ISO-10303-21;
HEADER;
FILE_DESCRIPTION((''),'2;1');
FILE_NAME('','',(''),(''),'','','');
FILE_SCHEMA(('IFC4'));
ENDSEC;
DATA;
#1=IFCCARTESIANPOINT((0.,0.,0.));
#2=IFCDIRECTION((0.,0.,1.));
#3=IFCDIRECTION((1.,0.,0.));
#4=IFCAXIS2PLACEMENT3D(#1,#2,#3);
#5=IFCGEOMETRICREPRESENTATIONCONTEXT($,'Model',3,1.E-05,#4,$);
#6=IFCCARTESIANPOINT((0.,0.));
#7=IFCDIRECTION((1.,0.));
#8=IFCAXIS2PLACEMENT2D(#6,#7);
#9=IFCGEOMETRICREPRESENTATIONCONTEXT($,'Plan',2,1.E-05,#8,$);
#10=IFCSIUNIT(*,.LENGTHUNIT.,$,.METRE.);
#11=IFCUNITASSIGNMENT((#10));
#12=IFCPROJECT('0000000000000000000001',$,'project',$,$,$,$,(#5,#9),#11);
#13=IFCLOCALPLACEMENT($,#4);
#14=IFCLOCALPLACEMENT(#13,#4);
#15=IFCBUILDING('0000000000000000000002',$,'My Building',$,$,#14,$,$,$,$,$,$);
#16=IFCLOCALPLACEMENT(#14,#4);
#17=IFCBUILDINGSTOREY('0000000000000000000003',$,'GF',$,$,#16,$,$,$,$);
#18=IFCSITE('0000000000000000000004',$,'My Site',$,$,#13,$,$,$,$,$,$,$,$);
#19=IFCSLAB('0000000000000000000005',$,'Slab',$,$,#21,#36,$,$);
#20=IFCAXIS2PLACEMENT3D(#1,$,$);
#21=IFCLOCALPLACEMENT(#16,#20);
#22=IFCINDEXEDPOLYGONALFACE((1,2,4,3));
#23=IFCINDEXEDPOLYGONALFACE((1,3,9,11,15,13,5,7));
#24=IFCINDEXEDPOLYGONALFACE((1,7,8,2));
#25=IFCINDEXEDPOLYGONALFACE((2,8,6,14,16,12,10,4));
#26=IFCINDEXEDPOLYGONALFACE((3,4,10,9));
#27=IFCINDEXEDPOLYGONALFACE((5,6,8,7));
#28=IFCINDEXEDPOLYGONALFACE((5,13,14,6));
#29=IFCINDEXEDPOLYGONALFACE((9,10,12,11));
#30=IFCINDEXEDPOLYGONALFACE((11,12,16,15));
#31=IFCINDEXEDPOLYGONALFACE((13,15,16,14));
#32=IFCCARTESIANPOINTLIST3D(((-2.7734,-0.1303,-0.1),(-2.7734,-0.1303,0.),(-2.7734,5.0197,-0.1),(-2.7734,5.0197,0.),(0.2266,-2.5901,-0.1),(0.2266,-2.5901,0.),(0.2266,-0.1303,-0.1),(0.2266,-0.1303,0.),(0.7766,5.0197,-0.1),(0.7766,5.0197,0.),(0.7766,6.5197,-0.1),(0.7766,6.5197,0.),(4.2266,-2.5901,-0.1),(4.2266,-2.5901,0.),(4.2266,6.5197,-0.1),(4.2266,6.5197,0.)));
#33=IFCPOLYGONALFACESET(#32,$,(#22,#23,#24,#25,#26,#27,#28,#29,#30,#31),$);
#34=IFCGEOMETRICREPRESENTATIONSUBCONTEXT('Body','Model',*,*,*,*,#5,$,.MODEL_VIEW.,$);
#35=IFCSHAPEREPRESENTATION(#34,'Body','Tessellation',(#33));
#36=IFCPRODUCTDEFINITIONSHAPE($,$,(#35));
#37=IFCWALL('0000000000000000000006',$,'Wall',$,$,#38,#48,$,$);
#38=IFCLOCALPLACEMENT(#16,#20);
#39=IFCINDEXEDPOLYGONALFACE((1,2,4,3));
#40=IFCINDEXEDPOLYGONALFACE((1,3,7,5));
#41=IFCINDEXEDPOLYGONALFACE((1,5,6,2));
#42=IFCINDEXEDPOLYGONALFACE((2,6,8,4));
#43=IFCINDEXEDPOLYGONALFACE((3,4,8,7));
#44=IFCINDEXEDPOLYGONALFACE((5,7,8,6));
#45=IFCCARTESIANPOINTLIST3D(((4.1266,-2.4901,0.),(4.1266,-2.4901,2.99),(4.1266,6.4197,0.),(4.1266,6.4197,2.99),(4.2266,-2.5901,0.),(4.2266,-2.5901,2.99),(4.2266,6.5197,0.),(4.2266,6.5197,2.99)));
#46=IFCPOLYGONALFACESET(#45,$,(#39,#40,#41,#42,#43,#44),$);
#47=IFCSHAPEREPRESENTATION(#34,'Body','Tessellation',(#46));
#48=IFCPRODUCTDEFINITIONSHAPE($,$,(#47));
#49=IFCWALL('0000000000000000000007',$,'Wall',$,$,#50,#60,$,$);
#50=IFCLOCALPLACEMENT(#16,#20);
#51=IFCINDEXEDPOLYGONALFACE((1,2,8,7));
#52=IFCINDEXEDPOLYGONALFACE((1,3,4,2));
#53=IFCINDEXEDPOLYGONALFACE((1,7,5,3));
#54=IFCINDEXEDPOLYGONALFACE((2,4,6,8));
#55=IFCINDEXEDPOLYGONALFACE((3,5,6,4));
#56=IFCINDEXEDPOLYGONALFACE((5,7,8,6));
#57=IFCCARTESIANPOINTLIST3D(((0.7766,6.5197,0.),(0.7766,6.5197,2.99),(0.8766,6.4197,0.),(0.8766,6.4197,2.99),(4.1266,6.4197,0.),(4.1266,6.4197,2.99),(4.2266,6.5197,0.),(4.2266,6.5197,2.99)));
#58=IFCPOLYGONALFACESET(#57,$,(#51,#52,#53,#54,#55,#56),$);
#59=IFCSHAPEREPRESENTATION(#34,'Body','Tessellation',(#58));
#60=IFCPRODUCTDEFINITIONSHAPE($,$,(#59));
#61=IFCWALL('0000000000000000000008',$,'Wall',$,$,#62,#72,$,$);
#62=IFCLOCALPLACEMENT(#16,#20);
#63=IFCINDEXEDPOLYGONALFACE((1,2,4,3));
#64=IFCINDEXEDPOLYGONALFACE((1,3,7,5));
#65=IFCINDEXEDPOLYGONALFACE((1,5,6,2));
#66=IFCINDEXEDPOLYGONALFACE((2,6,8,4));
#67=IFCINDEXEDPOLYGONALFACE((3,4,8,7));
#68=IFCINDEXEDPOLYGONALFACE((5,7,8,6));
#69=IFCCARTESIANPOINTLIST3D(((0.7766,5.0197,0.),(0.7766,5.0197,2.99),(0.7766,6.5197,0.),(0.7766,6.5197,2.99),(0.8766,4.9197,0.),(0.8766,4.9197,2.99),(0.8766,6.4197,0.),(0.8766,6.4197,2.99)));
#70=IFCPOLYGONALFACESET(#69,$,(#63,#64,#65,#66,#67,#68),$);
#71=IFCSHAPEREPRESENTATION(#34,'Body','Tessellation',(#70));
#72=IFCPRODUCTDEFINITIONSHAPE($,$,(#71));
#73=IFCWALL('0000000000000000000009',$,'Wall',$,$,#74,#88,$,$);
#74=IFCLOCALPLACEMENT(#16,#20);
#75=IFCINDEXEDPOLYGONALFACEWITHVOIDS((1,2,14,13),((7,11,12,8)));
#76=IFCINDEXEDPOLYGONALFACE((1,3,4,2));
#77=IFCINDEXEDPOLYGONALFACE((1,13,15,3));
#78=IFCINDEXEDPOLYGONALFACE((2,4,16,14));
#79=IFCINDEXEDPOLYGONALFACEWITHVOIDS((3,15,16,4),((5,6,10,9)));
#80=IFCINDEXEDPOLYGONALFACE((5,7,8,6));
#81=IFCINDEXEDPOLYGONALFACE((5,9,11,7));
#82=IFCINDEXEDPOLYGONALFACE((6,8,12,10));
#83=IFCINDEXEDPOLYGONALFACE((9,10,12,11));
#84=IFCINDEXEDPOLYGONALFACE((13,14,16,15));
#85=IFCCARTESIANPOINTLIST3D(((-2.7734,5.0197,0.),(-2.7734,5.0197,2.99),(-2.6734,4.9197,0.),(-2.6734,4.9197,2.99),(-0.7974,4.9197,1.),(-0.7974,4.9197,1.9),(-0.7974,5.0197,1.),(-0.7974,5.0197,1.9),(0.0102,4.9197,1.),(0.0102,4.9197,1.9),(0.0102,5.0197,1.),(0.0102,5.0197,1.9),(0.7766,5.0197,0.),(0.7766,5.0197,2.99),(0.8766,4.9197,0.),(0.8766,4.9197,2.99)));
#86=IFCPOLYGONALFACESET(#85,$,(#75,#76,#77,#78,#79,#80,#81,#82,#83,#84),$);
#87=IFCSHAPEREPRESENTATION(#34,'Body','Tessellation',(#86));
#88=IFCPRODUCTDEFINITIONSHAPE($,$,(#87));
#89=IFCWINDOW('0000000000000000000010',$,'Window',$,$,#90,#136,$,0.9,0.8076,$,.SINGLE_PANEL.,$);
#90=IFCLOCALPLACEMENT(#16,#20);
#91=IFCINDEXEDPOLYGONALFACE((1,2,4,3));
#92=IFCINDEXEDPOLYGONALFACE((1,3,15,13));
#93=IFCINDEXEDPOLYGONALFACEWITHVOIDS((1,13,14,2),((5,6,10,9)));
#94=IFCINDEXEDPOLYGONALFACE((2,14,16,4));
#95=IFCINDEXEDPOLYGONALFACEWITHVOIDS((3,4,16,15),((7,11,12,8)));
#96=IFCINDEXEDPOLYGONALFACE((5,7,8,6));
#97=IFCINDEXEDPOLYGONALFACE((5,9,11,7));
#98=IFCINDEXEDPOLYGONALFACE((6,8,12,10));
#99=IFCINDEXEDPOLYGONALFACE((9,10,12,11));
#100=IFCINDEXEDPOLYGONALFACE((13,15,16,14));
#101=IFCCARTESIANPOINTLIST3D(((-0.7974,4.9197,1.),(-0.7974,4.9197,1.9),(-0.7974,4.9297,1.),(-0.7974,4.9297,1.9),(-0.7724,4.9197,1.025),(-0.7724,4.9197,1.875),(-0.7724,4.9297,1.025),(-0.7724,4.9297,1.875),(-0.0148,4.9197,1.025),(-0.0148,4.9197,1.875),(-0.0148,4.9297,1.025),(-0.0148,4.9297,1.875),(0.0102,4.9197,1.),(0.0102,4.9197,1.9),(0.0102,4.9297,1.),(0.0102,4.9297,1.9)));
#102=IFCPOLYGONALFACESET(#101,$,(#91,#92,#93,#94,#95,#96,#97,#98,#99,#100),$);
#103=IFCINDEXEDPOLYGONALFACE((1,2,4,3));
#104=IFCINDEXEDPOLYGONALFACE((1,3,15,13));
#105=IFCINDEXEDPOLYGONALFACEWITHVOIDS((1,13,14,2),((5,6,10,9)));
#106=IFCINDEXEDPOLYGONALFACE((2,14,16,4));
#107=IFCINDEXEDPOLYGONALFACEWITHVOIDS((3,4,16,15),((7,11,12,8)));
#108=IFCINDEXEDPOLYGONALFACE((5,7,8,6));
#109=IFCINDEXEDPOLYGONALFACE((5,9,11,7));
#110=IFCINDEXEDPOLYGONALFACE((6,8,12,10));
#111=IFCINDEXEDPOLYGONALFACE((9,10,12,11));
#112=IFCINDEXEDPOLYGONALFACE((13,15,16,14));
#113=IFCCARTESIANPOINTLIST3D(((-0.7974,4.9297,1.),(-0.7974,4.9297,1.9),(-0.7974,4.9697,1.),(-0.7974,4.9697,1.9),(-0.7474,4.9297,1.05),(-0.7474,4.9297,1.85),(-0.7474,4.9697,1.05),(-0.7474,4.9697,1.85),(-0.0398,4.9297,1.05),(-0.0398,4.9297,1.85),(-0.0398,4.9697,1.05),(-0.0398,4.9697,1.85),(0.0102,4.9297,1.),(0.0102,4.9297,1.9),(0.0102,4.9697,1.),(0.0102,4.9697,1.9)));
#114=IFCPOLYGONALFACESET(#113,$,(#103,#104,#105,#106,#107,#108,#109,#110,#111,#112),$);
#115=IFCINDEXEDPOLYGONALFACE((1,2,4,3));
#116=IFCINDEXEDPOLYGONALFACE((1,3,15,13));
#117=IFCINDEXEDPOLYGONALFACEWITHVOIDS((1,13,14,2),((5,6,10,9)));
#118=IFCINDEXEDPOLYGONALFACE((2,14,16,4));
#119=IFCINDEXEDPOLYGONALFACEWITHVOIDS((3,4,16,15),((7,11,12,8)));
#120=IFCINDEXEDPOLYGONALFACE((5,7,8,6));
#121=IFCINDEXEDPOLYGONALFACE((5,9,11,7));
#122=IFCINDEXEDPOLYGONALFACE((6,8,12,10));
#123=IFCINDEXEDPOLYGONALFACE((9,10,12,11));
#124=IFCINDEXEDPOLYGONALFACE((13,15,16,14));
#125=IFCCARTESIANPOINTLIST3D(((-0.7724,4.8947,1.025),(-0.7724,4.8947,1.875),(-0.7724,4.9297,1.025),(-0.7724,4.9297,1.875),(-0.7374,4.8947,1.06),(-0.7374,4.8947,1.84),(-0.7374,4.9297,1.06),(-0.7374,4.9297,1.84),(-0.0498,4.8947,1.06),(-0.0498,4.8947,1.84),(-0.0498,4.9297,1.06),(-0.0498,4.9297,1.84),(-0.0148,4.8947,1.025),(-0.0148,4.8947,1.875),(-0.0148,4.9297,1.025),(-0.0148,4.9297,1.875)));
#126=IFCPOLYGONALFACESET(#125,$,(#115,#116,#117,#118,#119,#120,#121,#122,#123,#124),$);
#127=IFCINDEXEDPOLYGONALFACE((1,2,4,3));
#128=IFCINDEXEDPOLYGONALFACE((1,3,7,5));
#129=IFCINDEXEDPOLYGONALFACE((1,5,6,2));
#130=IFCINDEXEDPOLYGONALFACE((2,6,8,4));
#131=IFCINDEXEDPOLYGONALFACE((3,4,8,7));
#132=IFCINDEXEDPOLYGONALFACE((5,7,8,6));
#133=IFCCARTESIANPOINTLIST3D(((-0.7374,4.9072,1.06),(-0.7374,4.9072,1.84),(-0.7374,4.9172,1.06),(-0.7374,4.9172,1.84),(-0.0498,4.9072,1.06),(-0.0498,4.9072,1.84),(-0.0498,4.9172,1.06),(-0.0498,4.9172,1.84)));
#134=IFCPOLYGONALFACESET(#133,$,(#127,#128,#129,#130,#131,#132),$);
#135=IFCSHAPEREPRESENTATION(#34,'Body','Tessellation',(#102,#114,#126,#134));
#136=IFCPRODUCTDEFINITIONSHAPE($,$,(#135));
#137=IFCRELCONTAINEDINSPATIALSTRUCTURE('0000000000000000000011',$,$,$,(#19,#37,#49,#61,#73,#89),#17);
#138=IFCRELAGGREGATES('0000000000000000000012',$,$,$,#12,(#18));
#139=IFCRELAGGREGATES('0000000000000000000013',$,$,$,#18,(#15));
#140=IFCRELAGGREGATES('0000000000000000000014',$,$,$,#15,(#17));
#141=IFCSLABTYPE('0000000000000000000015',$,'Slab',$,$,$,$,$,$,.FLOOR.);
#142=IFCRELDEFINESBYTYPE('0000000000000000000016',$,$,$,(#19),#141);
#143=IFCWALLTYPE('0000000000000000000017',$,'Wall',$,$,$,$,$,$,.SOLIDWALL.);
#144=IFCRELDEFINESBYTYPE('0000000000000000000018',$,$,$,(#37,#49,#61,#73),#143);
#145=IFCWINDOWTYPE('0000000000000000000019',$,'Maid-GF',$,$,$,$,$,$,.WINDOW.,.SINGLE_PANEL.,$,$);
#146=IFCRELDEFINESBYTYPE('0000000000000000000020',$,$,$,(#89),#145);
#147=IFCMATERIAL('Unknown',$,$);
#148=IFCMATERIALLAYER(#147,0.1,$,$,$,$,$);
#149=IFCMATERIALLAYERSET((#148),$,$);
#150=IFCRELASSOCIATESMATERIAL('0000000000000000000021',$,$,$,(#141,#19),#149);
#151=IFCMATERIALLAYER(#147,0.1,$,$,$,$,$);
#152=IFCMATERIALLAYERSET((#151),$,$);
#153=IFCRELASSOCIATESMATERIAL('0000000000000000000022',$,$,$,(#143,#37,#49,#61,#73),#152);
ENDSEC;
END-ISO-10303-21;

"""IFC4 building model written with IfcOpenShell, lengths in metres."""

from ifc_helpers import new_model, entity, si_unit, frame, origin_with_axes, origin_2d_with_axis, place, context, subcontext, project, spatial, line, indexed_curve, outline, extrude, shape, source, transform, mapped, material, layer, layer_set, layer_usage, type_object, type_shapes, element, fill, save


model = new_model("IFC4")

# Units and contexts
model_context = context("Model", 3, precision=1e-05, world=origin_with_axes())
plan_context = context("Plan", 2, precision=1e-05, world=origin_2d_with_axis())
body_context_1 = subcontext(model_context, "Body", "Model", "MODEL_VIEW")
body_context_2 = subcontext(plan_context, "Body", "Plan", "PLAN_VIEW")
ifc_project = project(units=[si_unit("LENGTHUNIT", "METRE")], contexts=[model_context, plan_context])

# Site, building, storey
site_placement = place(None, origin_with_axes())
site = spatial("IfcSite", under=ifc_project, at=site_placement, Name="My Site")
building_placement = place(site_placement, origin_with_axes())
building = spatial("IfcBuilding", under=site, at=building_placement, Name="My Building")
storey_placement = place(building_placement, origin_with_axes())
storey = spatial("IfcBuildingStorey", under=building, at=storey_placement, Name="GF")

# Slab
ifc_material = material(Name="Unknown")
ifc_layer_1 = layer(ifc_material, 0.1)
ifc_layer_set_1 = layer_set([ifc_layer_1])
ifc_layer_usage_1 = layer_usage(ifc_layer_set_1, "AXIS3", "POSITIVE", -0.1)
slab_type = type_object("IfcSlabType", Name="Slab", PredefinedType="FLOOR", material=ifc_layer_set_1)
slab_placement = place(storey_placement, frame((4.2266, -2.5901, 0.0), z_axis=(0.0, 0.0, 1.0), x_axis=(1.0, 0.0, 0.0)))
element("IfcSlab", 1, at=slab_placement, inside=storey, type_object=slab_type, material=ifc_layer_usage_1, Name="Slab", context=body_context_1, shape_type="SweptSolid", body=[
    extrude(outline(indexed_curve([(0.0, 0.0), (0.0, 9.1098), (-3.45, 9.1098), (-3.45, 7.6098), (-7.0, 7.6098), (-7.0, 2.4598), (-4.0, 2.4598), (-4.0, 0.0), (0.0, 0.0)])), frame((0.0, 0.0, -0.1), z_axis=(0.0, 0.0, 1.0), x_axis=(1.0, 0.0, 0.0)), (0.0, 0.0, 1.0), 0.1),
])

# Shared definitions
ifc_layer_2 = layer(ifc_material, 0.1)
ifc_layer_set_2 = layer_set([ifc_layer_2])
wall_type = type_object("IfcWallType", Name="Wall", PredefinedType="SOLIDWALL", material=ifc_layer_set_2)

# Walls
ifc_layer_usage_2 = layer_usage(ifc_layer_set_2, "AXIS2", "POSITIVE", 0.0)
wall_1_placement = place(storey_placement, frame((4.2266, -2.5901, 0.0), z_axis=(0.0, 0.0, 1.0), x_axis=(0.0, 1.0, 0.0)))
element("IfcWall", 2, at=wall_1_placement, inside=storey, type_object=wall_type, material=ifc_layer_usage_2, Name="Wall", context=body_context_1, shape_type="SweptSolid", body=[
    extrude(outline(indexed_curve([(0.0, 0.0), (0.1, 0.1), (9.0098, 0.1), (9.1098, 0.0)], segments=[line(1, 2, 3, 4, 1)])), origin_with_axes(), (0.0, 0.0, 1.0), 2.99),
])
ifc_layer_usage_3 = layer_usage(ifc_layer_set_2, "AXIS2", "POSITIVE", 0.0)
wall_2_placement = place(storey_placement, frame((4.2266, 6.5197, 0.0), z_axis=(0.0, 0.0, 1.0), x_axis=(-1.0, 0.0, 0.0)))
element("IfcWall", 3, at=wall_2_placement, inside=storey, type_object=wall_type, material=ifc_layer_usage_3, Name="Wall", context=body_context_1, shape_type="SweptSolid", body=[
    extrude(outline(indexed_curve([(0.0, 0.0), (0.1, 0.1), (3.35, 0.1), (3.45, 0.0)], segments=[line(1, 2, 3, 4, 1)])), origin_with_axes(), (0.0, 0.0, 1.0), 2.99),
])
ifc_layer_usage_4 = layer_usage(ifc_layer_set_2, "AXIS2", "POSITIVE", 0.0)
wall_3_placement = place(storey_placement, frame((0.7766, 6.5197, 0.0), z_axis=(0.0, 0.0, 1.0), x_axis=(0.0, -1.0, 0.0)))
element("IfcWall", 4, at=wall_3_placement, inside=storey, type_object=wall_type, material=ifc_layer_usage_4, Name="Wall", context=body_context_1, shape_type="SweptSolid", body=[
    extrude(outline(indexed_curve([(0.0, 0.0), (0.1, 0.1), (1.6, 0.1), (1.5, 0.0)], segments=[line(1, 2, 3, 4, 1)])), origin_with_axes(), (0.0, 0.0, 1.0), 2.99),
])

# Wall, opening, window
ifc_layer_usage_5 = layer_usage(ifc_layer_set_2, "AXIS2", "POSITIVE", 0.0)
wall_4_placement = place(storey_placement, frame((0.7766, 5.0197, 0.0), z_axis=(0.0, 0.0, 1.0), x_axis=(-1.0, 0.0, 0.0)))
wall_4 = element("IfcWall", 5, at=wall_4_placement, inside=storey, type_object=wall_type, material=ifc_layer_usage_5, Name="Wall", context=body_context_1, shape_type="SweptSolid", body=[
    extrude(outline(indexed_curve([(0.0, 0.0), (-0.1, 0.1), (3.45, 0.1), (3.55, 0.0)], segments=[line(1, 2, 3, 4, 1)])), origin_with_axes(), (0.0, 0.0, 1.0), 2.99),
])
shared_shape_1 = source(origin_with_axes(), body_context_1, "Body", "SweptSolid", [
    extrude(outline(indexed_curve([(0.0, 0.0), (0.8076, 0.0), (0.8076, 0.9), (0.0, 0.9)], segments=[line(1, 2, 3, 4, 1)])), frame((0.0, -0.6, 0.0), z_axis=(0.0, -1.0, 0.0), x_axis=(1.0, 0.0, 0.0)), (0.0, 0.0, -1.0), 1.2),
])
opening_1_placement = place(wall_4_placement, frame((0.7664, 0.0, 1.0), z_axis=(0.0, 0.0, 1.0), x_axis=(1.0, 0.0, 0.0)))
opening_1 = element("IfcOpeningElement", 6, at=opening_1_placement, cuts=wall_4, PredefinedType="OPENING", context=body_context_1, shape_type="MappedRepresentation", body=[
    mapped(shared_shape_1, transform((0.0, 0.0, 0.0), x_axis=(1.0, 0.0, 0.0), y_axis=(0.0, 1.0, 0.0), z_axis=(0.0, 0.0, 1.0), scale=1.0)),
])
window_type_1 = type_object("IfcWindowType", Name="Maid-GF", PartitioningType="SINGLE_PANEL", PredefinedType="WINDOW")
shared_shape_2 = source(origin_with_axes(), body_context_1, "Body", "SweptSolid", [
    extrude(outline(indexed_curve([(0.0, 0.0), (0.8076, 0.0), (0.8076, 0.9), (0.0, 0.9)], segments=[line(1, 2, 3, 4, 1)]), holes=[indexed_curve([(0.025, 0.025), (0.7826, 0.025), (0.7826, 0.875), (0.025, 0.875)], segments=[line(1, 2, 3, 4, 1)])]), frame((0.0, 0.09, 0.0), z_axis=(0.0, -1.0, 0.0), x_axis=(1.0, 0.0, 0.0)), (0.0, 0.0, -1.0), 0.01),
    extrude(outline(indexed_curve([(0.0, 0.0), (0.8076, 0.0), (0.8076, 0.9), (0.0, 0.9)], segments=[line(1, 2, 3, 4, 1)]), holes=[indexed_curve([(0.05, 0.05), (0.7576, 0.05), (0.7576, 0.85), (0.05, 0.85)], segments=[line(1, 2, 3, 4, 1)])]), frame((0.0, 0.05, 0.0), z_axis=(0.0, -1.0, 0.0), x_axis=(1.0, 0.0, 0.0)), (0.0, 0.0, -1.0), 0.04),
    extrude(outline(indexed_curve([(0.0, 0.0), (0.7576, 0.0), (0.7576, 0.85), (0.0, 0.85)], segments=[line(1, 2, 3, 4, 1)]), holes=[indexed_curve([(0.035, 0.035), (0.7226, 0.035), (0.7226, 0.815), (0.035, 0.815)], segments=[line(1, 2, 3, 4, 1)])]), frame((0.025, 0.09, 0.025), z_axis=(0.0, -1.0, 0.0), x_axis=(1.0, 0.0, 0.0)), (0.0, 0.0, -1.0), 0.035),
    extrude(outline(indexed_curve([(0.035, 0.035), (0.7226, 0.035), (0.7226, 0.815), (0.035, 0.815)], segments=[line(1, 2, 3, 4, 1)])), frame((0.025, 0.1025, 0.025), z_axis=(0.0, -1.0, 0.0), x_axis=(1.0, 0.0, 0.0)), (0.0, 0.0, -1.0), 0.01),
])
shared_shape_3 = source(origin_with_axes(), body_context_2, "Body", "Curve2D", [
    entity("IfcIndexedPolyCurve", entity("IfcCartesianPointList2D", [[0.05, 0.05], [0.7576, 0.05]])),
    entity("IfcIndexedPolyCurve", entity("IfcCartesianPointList2D", [[0.0, 0.1], [0.025, 0.1], [0.025, 0.09], [0.05, 0.09], [0.05, 0.05], [0.0, 0.05]]), [entity("IfcLineIndex", [1, 2, 3, 4, 5, 6, 1])]),
    entity("IfcIndexedPolyCurve", entity("IfcCartesianPointList2D", [[0.8076, 0.1], [0.7826, 0.1], [0.7826, 0.09], [0.7576, 0.09], [0.7576, 0.05], [0.8076, 0.05]]), [entity("IfcLineIndex", [1, 2, 3, 4, 5, 6, 1])]),
    entity("IfcIndexedPolyCurve", entity("IfcCartesianPointList2D", [[0.025, 0.09], [0.06, 0.09], [0.06, 0.125], [0.025, 0.125]]), [entity("IfcLineIndex", [1, 2, 3, 4, 1])]),
    entity("IfcIndexedPolyCurve", entity("IfcCartesianPointList2D", [[0.7826, 0.09], [0.7476, 0.09], [0.7476, 0.125], [0.7826, 0.125]]), [entity("IfcLineIndex", [1, 2, 3, 4, 1])]),
    entity("IfcIndexedPolyCurve", entity("IfcCartesianPointList2D", [[0.06, 0.09], [0.7476, 0.09]])),
    entity("IfcIndexedPolyCurve", entity("IfcCartesianPointList2D", [[0.06, 0.125], [0.7476, 0.125]])),
    entity("IfcIndexedPolyCurve", entity("IfcCartesianPointList2D", [[0.06, 0.1075], [0.7476, 0.1075]])),
])
type_shapes(window_type_1, [shared_shape_2, shared_shape_3])
window_1_placement = place(opening_1_placement, origin_with_axes())
window_1 = element("IfcWindow", 7, at=window_1_placement, inside=storey, type_object=window_type_1, Name="Window", OverallHeight=0.9, OverallWidth=0.8076, PartitioningType="SINGLE_PANEL", shapes=[
    shape(body_context_1, "Body", "MappedRepresentation", [mapped(shared_shape_2, transform((0.0, 0.0, 0.0), x_axis=(1.0, 0.0, 0.0), y_axis=(0.0, 1.0, 0.0), z_axis=(0.0, 0.0, 1.0), scale=1.0))]),
    shape(body_context_2, "Body", "MappedRepresentation", [mapped(shared_shape_3, transform((0.0, 0.0, 0.0), x_axis=(1.0, 0.0, 0.0), y_axis=(0.0, 1.0, 0.0), z_axis=(0.0, 0.0, 1.0), scale=1.0))]),
])
fill(opening_1, window_1)

save(model, "model.ifc")
